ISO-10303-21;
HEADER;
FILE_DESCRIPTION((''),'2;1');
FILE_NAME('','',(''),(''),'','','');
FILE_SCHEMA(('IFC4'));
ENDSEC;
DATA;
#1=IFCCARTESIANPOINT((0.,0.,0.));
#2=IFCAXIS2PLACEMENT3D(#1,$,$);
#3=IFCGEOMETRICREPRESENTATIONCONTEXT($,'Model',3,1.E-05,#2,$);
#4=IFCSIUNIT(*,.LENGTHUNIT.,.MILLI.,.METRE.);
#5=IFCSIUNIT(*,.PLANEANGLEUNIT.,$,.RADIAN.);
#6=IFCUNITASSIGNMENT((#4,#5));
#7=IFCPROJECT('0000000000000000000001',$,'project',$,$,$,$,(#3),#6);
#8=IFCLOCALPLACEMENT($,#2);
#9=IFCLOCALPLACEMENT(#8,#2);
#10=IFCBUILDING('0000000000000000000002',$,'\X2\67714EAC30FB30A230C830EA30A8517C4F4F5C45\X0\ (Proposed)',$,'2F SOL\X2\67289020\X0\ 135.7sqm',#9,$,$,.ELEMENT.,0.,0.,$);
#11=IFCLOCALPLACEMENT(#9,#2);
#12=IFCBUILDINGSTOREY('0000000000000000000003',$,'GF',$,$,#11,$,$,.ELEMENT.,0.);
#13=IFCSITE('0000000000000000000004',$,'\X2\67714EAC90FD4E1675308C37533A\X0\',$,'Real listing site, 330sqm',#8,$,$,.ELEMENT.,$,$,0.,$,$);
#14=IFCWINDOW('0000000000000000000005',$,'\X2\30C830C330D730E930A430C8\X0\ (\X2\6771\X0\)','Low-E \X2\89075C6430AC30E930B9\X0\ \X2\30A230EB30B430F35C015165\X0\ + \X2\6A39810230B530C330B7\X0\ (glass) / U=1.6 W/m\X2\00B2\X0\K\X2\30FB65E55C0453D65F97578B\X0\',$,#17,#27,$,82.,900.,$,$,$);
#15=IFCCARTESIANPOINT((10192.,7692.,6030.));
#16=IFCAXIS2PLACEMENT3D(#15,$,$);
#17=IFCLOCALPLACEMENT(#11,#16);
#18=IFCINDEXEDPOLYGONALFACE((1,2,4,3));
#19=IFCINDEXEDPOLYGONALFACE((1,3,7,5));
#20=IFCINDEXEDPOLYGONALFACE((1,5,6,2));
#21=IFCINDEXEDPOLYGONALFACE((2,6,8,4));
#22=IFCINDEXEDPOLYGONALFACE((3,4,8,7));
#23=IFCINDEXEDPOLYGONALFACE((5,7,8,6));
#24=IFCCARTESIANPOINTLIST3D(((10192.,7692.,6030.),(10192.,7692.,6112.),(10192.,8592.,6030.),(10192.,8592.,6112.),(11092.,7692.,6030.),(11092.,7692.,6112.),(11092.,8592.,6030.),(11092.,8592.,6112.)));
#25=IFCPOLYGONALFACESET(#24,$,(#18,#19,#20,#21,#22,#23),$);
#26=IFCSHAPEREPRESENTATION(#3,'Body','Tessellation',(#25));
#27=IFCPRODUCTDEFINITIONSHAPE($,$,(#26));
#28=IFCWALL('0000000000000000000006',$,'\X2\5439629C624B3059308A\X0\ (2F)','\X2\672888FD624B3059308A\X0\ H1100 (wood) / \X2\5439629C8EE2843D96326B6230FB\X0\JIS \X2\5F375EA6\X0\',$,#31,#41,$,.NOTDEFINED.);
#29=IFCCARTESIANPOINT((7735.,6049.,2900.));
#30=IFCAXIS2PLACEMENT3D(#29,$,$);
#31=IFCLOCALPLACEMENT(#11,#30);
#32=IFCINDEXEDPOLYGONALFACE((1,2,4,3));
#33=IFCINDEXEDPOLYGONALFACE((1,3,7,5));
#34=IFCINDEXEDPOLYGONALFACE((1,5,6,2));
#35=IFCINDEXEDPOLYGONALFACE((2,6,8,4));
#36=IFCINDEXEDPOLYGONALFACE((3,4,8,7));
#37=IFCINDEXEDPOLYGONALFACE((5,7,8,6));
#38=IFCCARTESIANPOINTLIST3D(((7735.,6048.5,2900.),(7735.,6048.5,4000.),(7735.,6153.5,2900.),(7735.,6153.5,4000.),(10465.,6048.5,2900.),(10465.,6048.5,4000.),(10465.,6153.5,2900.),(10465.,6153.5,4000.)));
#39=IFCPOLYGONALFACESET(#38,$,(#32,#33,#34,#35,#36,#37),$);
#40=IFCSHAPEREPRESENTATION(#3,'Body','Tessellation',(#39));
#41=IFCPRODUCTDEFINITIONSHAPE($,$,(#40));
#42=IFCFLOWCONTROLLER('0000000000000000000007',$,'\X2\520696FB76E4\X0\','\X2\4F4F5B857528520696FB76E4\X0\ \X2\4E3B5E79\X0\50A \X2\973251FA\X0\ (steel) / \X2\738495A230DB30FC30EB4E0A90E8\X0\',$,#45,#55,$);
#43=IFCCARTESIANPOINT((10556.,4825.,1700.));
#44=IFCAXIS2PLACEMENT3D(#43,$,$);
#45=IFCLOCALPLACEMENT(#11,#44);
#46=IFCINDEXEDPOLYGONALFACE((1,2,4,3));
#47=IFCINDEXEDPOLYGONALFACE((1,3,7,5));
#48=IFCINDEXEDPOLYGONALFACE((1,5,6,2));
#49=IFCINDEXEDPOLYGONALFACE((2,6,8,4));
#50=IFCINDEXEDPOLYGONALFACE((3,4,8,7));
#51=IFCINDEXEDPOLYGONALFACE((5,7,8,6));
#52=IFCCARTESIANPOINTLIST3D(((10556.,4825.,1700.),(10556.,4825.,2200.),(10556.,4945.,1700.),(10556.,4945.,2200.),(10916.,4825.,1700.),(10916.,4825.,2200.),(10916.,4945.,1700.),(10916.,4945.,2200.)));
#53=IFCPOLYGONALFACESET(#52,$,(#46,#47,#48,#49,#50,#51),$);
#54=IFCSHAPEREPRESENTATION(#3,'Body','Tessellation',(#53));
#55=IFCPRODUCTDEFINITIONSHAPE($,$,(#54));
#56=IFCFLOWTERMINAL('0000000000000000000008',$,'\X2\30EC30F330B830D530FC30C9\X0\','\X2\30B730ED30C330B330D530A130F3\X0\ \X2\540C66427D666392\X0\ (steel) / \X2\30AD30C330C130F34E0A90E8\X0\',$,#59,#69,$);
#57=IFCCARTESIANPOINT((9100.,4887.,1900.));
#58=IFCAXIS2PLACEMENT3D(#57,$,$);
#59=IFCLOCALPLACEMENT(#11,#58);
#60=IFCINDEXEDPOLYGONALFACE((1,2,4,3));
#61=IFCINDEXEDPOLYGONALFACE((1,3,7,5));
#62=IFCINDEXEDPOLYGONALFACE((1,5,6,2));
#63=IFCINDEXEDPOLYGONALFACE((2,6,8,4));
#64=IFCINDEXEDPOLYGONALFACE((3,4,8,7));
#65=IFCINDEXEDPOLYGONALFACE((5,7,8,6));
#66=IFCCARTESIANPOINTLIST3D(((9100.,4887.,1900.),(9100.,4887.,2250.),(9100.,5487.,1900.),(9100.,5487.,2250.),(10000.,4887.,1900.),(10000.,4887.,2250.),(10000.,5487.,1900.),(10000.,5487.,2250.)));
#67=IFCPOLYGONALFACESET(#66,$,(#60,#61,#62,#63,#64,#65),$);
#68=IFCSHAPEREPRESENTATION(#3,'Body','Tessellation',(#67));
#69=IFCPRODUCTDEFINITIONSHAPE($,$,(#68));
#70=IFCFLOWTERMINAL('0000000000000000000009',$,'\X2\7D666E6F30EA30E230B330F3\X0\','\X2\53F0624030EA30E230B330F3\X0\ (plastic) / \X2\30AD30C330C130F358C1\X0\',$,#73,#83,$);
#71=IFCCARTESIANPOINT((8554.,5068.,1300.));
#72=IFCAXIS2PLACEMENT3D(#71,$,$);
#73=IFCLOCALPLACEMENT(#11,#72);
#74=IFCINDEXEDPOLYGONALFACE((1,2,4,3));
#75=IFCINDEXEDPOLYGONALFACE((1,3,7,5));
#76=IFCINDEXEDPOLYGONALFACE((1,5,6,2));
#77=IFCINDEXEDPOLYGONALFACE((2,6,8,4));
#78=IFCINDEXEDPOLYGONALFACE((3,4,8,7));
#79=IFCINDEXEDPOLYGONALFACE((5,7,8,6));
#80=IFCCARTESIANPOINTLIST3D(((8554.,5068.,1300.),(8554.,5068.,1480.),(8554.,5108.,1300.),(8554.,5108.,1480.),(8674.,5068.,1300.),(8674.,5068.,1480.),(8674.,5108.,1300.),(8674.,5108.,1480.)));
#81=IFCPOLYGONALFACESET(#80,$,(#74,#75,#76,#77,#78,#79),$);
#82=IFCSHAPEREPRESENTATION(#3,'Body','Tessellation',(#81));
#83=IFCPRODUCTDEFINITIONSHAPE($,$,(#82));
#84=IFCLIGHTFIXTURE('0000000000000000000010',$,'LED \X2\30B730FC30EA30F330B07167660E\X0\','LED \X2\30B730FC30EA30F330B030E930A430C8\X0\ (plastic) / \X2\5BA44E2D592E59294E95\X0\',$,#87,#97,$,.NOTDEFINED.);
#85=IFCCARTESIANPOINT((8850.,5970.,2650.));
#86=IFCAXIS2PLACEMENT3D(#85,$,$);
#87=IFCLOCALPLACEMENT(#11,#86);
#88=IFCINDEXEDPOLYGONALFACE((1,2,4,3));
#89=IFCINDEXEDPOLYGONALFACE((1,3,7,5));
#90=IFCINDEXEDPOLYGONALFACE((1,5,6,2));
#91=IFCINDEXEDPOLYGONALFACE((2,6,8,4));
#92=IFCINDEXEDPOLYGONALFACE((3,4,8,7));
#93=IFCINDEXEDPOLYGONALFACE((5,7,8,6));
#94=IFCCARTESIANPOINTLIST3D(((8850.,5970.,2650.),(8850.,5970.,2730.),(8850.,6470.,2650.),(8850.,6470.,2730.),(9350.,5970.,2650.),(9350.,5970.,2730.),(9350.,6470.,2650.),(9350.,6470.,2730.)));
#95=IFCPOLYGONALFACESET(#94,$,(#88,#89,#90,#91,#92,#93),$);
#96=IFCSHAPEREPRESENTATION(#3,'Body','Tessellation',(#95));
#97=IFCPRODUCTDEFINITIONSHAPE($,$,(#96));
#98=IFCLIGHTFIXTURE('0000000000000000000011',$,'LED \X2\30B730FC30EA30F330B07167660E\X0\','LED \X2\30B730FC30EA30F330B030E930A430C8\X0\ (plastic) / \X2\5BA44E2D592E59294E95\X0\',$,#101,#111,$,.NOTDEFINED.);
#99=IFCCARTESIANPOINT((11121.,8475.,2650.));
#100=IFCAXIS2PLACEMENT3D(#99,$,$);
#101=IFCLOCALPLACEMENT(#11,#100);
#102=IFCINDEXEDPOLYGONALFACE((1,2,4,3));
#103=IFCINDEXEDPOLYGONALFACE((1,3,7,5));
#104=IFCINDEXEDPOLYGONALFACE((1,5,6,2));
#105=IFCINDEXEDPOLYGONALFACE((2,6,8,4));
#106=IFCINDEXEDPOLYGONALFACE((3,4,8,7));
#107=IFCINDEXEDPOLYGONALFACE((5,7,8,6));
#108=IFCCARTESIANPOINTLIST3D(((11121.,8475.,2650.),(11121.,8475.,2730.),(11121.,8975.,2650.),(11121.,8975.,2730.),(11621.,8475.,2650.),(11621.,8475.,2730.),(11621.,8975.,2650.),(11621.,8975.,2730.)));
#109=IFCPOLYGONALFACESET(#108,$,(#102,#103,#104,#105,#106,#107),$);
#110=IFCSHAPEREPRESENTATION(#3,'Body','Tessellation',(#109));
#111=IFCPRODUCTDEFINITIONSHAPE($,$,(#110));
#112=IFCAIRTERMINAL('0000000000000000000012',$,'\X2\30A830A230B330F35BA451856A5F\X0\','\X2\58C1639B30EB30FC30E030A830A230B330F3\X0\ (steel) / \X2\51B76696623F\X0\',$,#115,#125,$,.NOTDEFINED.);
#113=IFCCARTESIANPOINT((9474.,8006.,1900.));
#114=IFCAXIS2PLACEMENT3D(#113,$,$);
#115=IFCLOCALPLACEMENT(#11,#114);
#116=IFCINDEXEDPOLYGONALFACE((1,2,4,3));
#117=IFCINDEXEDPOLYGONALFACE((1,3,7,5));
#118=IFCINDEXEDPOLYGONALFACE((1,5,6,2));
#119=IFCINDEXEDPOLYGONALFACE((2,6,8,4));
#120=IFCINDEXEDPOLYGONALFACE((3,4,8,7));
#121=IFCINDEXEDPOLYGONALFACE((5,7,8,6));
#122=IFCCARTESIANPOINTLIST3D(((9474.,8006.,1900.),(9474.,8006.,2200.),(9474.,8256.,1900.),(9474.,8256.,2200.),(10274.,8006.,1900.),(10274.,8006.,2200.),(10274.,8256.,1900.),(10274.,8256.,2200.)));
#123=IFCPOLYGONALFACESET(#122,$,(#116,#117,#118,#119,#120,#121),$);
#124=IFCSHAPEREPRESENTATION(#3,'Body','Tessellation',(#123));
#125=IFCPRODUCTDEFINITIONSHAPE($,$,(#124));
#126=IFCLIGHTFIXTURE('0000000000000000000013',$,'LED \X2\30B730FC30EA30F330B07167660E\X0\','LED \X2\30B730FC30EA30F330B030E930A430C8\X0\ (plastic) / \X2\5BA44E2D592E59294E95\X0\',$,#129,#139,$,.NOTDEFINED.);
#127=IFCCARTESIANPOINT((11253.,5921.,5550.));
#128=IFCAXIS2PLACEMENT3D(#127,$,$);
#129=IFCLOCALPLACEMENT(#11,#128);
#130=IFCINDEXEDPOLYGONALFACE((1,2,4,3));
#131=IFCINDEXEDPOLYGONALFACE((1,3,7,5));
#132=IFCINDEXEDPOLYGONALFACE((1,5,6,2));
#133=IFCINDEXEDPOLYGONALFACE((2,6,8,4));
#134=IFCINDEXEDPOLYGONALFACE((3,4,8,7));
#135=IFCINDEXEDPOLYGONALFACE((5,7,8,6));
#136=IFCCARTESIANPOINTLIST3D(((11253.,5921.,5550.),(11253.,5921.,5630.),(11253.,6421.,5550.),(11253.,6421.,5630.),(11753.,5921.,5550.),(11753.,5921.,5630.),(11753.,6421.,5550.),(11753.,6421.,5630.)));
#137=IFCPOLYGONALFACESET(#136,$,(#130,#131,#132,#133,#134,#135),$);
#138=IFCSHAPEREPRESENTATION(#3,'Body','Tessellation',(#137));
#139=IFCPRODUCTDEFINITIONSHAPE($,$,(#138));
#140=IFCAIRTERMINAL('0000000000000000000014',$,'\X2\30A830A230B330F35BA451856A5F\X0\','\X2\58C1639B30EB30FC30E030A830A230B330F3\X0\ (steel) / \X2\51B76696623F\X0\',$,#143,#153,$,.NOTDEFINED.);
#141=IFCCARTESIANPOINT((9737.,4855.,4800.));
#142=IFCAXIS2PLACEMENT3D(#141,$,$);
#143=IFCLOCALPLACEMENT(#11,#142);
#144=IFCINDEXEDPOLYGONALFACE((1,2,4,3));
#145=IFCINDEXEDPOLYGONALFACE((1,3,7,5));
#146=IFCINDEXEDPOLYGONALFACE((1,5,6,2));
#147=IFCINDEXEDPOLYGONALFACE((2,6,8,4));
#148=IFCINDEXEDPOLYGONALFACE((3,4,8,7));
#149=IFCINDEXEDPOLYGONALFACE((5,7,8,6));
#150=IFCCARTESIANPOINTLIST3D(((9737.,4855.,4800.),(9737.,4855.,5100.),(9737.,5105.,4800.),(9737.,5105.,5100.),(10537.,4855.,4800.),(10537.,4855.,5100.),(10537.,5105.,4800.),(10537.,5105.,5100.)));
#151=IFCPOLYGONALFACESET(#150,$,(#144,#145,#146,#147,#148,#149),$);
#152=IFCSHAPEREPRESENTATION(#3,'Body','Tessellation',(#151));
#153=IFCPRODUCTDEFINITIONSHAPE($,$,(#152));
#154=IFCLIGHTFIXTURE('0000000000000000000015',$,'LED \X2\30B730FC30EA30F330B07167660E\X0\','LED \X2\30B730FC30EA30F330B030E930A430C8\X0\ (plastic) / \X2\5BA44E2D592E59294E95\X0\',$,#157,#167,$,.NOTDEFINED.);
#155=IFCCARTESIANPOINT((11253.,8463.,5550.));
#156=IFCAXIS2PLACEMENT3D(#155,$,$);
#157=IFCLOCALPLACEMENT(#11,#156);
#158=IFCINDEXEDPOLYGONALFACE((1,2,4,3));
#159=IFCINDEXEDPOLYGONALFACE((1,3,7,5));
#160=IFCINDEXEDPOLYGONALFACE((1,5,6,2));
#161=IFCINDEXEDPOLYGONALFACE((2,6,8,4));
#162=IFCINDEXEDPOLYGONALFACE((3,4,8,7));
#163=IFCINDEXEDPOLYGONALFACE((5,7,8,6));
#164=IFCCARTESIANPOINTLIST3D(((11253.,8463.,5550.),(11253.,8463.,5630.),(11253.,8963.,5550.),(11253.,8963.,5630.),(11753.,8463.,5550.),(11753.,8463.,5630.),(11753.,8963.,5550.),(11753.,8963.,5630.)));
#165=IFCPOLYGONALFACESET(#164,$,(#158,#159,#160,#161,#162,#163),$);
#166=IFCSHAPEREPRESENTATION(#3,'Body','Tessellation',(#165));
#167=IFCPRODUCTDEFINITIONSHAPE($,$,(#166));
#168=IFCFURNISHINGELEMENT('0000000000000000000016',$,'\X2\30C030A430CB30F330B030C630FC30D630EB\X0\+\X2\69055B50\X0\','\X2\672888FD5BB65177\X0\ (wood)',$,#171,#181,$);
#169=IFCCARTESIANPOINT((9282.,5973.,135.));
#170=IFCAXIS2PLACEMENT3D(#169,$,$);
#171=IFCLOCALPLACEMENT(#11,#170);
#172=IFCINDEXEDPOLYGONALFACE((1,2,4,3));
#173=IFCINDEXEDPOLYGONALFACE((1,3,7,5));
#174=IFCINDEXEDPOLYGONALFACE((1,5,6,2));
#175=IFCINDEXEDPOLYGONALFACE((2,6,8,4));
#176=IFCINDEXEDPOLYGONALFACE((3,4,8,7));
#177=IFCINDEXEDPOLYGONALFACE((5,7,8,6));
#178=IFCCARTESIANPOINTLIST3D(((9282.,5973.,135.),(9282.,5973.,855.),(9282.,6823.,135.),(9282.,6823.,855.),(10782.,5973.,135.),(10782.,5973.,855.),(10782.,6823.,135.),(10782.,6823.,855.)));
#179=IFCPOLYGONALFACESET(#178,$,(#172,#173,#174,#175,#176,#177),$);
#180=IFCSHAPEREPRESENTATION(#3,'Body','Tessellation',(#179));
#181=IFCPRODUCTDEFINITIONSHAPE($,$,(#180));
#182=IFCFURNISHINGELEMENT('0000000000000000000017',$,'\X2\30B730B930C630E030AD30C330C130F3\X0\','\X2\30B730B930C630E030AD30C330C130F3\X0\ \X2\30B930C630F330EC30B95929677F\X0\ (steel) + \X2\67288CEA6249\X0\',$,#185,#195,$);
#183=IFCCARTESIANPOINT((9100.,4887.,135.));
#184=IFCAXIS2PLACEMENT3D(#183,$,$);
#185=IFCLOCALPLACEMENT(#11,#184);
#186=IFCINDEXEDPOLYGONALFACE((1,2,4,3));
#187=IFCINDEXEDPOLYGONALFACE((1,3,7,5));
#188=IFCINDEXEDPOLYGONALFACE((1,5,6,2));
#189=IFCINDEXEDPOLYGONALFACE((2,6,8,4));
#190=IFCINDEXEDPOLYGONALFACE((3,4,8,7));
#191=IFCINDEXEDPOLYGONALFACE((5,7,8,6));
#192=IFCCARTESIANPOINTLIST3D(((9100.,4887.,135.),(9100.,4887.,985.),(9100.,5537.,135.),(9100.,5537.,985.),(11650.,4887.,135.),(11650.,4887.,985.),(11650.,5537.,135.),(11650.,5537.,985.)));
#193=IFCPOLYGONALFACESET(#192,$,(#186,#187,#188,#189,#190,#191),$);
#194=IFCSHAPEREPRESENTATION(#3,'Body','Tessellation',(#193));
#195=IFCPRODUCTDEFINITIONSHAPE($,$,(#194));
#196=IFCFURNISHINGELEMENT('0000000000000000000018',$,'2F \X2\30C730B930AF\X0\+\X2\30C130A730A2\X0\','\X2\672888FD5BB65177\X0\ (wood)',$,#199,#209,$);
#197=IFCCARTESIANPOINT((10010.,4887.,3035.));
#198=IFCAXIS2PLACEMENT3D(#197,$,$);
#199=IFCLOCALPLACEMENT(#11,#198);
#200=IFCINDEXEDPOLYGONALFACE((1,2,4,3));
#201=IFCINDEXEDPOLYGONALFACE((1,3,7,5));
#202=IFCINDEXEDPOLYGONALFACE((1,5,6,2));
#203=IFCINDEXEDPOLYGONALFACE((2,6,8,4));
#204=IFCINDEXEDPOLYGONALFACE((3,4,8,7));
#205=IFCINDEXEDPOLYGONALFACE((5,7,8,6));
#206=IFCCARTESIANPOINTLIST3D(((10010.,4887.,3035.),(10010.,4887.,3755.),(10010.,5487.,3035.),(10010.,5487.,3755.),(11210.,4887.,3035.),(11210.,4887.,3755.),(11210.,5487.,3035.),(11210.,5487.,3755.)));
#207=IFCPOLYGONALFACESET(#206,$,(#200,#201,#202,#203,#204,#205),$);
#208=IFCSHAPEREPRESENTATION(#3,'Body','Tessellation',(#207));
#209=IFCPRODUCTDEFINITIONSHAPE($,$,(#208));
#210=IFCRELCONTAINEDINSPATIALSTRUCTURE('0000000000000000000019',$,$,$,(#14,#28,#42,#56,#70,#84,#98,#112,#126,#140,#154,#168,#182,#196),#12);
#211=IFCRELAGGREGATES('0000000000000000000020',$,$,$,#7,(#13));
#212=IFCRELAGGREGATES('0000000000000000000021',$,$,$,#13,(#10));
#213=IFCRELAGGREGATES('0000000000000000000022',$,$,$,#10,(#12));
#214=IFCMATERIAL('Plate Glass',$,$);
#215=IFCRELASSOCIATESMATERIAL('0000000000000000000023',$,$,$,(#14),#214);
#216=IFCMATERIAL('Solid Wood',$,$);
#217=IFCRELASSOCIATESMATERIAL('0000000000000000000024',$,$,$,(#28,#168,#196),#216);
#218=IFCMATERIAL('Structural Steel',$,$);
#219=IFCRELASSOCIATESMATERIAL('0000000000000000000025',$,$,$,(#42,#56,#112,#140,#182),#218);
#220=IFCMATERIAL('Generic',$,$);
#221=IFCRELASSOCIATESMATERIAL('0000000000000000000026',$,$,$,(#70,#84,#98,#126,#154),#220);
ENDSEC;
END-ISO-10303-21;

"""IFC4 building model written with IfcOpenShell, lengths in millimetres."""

from ifc_helpers import new_model, si_unit, frame, frame_2d, origin, place, context, project, spatial, rectangle, extrude, material, element, save


model = new_model("IFC4")

# Units and contexts
model_context = context("Model", 3, precision=1e-05, world=origin())
ifc_project = project(units=[si_unit("LENGTHUNIT", "METRE", prefix="MILLI"), si_unit("PLANEANGLEUNIT", "RADIAN")], contexts=[model_context])

# Site, building, storey
site_placement = place(None, origin())
site = spatial("IfcSite", under=ifc_project, at=site_placement, Name="東京都世田谷区", ObjectType="Real listing site, 330sqm", CompositionType="ELEMENT", RefElevation=0.0)
building_placement = place(site_placement, origin())
building = spatial("IfcBuilding", under=site, at=building_placement, Name="東京・アトリエ兼住居 (Proposed)", ObjectType="2F SOL木造 135.7sqm", CompositionType="ELEMENT", ElevationOfRefHeight=0.0, ElevationOfTerrain=0.0)
storey_placement = place(building_placement, origin())
storey = spatial("IfcBuildingStorey", under=building, at=storey_placement, Name="GF", CompositionType="ELEMENT", Elevation=0.0)

# Shared definitions
ifc_material_1 = material(Name="Solid Wood")

# Window
ifc_material_2 = material(Name="Plate Glass")
window_placement = place(storey_placement, frame((10192.0, 7692.0, 6030.0)))
element("IfcWindow", 1, at=window_placement, inside=storey, material=ifc_material_2, Name="トップライト (東)", Description="Low-E 複層ガラス アルゴン封入 + 樹脂サッシ (glass) / U=1.6 W/m²K・日射取得型", OverallHeight=82.0, OverallWidth=900.0, context=model_context, shape_type="SweptSolid", body=[
    extrude(rectangle(XDim=900.0, YDim=900.0, at=frame_2d((450.0, 450.0))), frame((10192.0, 7692.0, 6030.0)), (0.0, 0.0, 1.0), 82.0),
])

# Wall
wall_1_placement = place(storey_placement, frame((7735.0, 6049.0, 2900.0)))
element("IfcWall", 2, at=wall_1_placement, inside=storey, material=ifc_material_1, Name="吹抜手すり (2F)", Description="木製手すり H1100 (wood) / 吹抜転落防止・JIS 強度", PredefinedType="NOTDEFINED", context=model_context, shape_type="SweptSolid", body=[
    extrude(rectangle(XDim=2730.0, YDim=105.0, at=frame_2d((1365.0, 52.0))), frame((7735.0, 6049.0, 2900.0)), (0.0, 0.0, 1.0), 1100.0),
])

# Flow controller
ifc_material_3 = material(Name="Structural Steel")
flow_controller_placement = place(storey_placement, frame((10556.0, 4825.0, 1700.0)))
element("IfcFlowController", 3, at=flow_controller_placement, inside=storey, material=ifc_material_3, Name="分電盤", Description="住宅用分電盤 主幹50A 露出 (steel) / 玄関ホール上部", context=model_context, shape_type="SweptSolid", body=[
    extrude(rectangle(XDim=360.0, YDim=120.0, at=frame_2d((180.0, 60.0))), frame((10556.0, 4825.0, 1700.0)), (0.0, 0.0, 1.0), 500.0),
])

# Flow terminals
flow_terminal_1_placement = place(storey_placement, frame((9100.0, 4887.0, 1900.0)))
element("IfcFlowTerminal", 4, at=flow_terminal_1_placement, inside=storey, material=ifc_material_3, Name="レンジフード", Description="シロッコファン 同時給排 (steel) / キッチン上部", context=model_context, shape_type="SweptSolid", body=[
    extrude(rectangle(XDim=900.0, YDim=600.0, at=frame_2d((450.0, 300.0))), frame((9100.0, 4887.0, 1900.0)), (0.0, 0.0, 1.0), 350.0),
])
ifc_material_4 = material(Name="Generic")
flow_terminal_2_placement = place(storey_placement, frame((8554.0, 5068.0, 1300.0)))
element("IfcFlowTerminal", 5, at=flow_terminal_2_placement, inside=storey, material=ifc_material_4, Name="給湯リモコン", Description="台所リモコン (plastic) / キッチン壁", context=model_context, shape_type="SweptSolid", body=[
    extrude(rectangle(XDim=120.0, YDim=40.0, at=frame_2d((60.0, 20.0))), frame((8554.0, 5068.0, 1300.0)), (0.0, 0.0, 1.0), 180.0),
])

# Light fixtures
light_fixture_1_placement = place(storey_placement, frame((8850.0, 5970.0, 2650.0)))
element("IfcLightFixture", 6, at=light_fixture_1_placement, inside=storey, material=ifc_material_4, Name="LED シーリング照明", Description="LED シーリングライト (plastic) / 室中央天井", PredefinedType="NOTDEFINED", context=model_context, shape_type="SweptSolid", body=[
    extrude(rectangle(XDim=500.0, YDim=500.0, at=frame_2d((250.0, 250.0))), frame((8850.0, 5970.0, 2650.0)), (0.0, 0.0, 1.0), 80.0),
])
light_fixture_2_placement = place(storey_placement, frame((11121.0, 8475.0, 2650.0)))
element("IfcLightFixture", 7, at=light_fixture_2_placement, inside=storey, material=ifc_material_4, Name="LED シーリング照明", Description="LED シーリングライト (plastic) / 室中央天井", PredefinedType="NOTDEFINED", context=model_context, shape_type="SweptSolid", body=[
    extrude(rectangle(XDim=500.0, YDim=500.0, at=frame_2d((250.0, 250.0))), frame((11121.0, 8475.0, 2650.0)), (0.0, 0.0, 1.0), 80.0),
])

# Air terminal
air_terminal_1_placement = place(storey_placement, frame((9474.0, 8006.0, 1900.0)))
element("IfcAirTerminal", 8, at=air_terminal_1_placement, inside=storey, material=ifc_material_3, Name="エアコン室内機", Description="壁掛ルームエアコン (steel) / 冷暖房", PredefinedType="NOTDEFINED", context=model_context, shape_type="SweptSolid", body=[
    extrude(rectangle(XDim=800.0, YDim=250.0, at=frame_2d((400.0, 125.0))), frame((9474.0, 8006.0, 1900.0)), (0.0, 0.0, 1.0), 300.0),
])

# Light fixture
light_fixture_3_placement = place(storey_placement, frame((11253.0, 5921.0, 5550.0)))
element("IfcLightFixture", 9, at=light_fixture_3_placement, inside=storey, material=ifc_material_4, Name="LED シーリング照明", Description="LED シーリングライト (plastic) / 室中央天井", PredefinedType="NOTDEFINED", context=model_context, shape_type="SweptSolid", body=[
    extrude(rectangle(XDim=500.0, YDim=500.0, at=frame_2d((250.0, 250.0))), frame((11253.0, 5921.0, 5550.0)), (0.0, 0.0, 1.0), 80.0),
])

# Air terminal
air_terminal_2_placement = place(storey_placement, frame((9737.0, 4855.0, 4800.0)))
element("IfcAirTerminal", 10, at=air_terminal_2_placement, inside=storey, material=ifc_material_3, Name="エアコン室内機", Description="壁掛ルームエアコン (steel) / 冷暖房", PredefinedType="NOTDEFINED", context=model_context, shape_type="SweptSolid", body=[
    extrude(rectangle(XDim=800.0, YDim=250.0, at=frame_2d((400.0, 125.0))), frame((9737.0, 4855.0, 4800.0)), (0.0, 0.0, 1.0), 300.0),
])

# Light fixture
light_fixture_4_placement = place(storey_placement, frame((11253.0, 8463.0, 5550.0)))
element("IfcLightFixture", 11, at=light_fixture_4_placement, inside=storey, material=ifc_material_4, Name="LED シーリング照明", Description="LED シーリングライト (plastic) / 室中央天井", PredefinedType="NOTDEFINED", context=model_context, shape_type="SweptSolid", body=[
    extrude(rectangle(XDim=500.0, YDim=500.0, at=frame_2d((250.0, 250.0))), frame((11253.0, 8463.0, 5550.0)), (0.0, 0.0, 1.0), 80.0),
])

# Furnishing elements
furnishing_1_placement = place(storey_placement, frame((9282.0, 5973.0, 135.0)))
element("IfcFurnishingElement", 12, at=furnishing_1_placement, inside=storey, material=ifc_material_1, Name="ダイニングテーブル+椅子", Description="木製家具 (wood)", context=model_context, shape_type="SweptSolid", body=[
    extrude(rectangle(XDim=1500.0, YDim=850.0, at=frame_2d((750.0, 425.0))), frame((9282.0, 5973.0, 135.0)), (0.0, 0.0, 1.0), 720.0),
])
furnishing_2_placement = place(storey_placement, frame((9100.0, 4887.0, 135.0)))
element("IfcFurnishingElement", 13, at=furnishing_2_placement, inside=storey, material=ifc_material_3, Name="システムキッチン", Description="システムキッチン ステンレス天板 (steel) + 木質扉", context=model_context, shape_type="SweptSolid", body=[
    extrude(rectangle(XDim=2550.0, YDim=650.0, at=frame_2d((1275.0, 325.0))), frame((9100.0, 4887.0, 135.0)), (0.0, 0.0, 1.0), 850.0),
])
furnishing_3_placement = place(storey_placement, frame((10010.0, 4887.0, 3035.0)))
element("IfcFurnishingElement", 14, at=furnishing_3_placement, inside=storey, material=ifc_material_1, Name="2F デスク+チェア", Description="木製家具 (wood)", context=model_context, shape_type="SweptSolid", body=[
    extrude(rectangle(XDim=1200.0, YDim=600.0, at=frame_2d((600.0, 300.0))), frame((10010.0, 4887.0, 3035.0)), (0.0, 0.0, 1.0), 720.0),
])

save(model, "model.ifc")
